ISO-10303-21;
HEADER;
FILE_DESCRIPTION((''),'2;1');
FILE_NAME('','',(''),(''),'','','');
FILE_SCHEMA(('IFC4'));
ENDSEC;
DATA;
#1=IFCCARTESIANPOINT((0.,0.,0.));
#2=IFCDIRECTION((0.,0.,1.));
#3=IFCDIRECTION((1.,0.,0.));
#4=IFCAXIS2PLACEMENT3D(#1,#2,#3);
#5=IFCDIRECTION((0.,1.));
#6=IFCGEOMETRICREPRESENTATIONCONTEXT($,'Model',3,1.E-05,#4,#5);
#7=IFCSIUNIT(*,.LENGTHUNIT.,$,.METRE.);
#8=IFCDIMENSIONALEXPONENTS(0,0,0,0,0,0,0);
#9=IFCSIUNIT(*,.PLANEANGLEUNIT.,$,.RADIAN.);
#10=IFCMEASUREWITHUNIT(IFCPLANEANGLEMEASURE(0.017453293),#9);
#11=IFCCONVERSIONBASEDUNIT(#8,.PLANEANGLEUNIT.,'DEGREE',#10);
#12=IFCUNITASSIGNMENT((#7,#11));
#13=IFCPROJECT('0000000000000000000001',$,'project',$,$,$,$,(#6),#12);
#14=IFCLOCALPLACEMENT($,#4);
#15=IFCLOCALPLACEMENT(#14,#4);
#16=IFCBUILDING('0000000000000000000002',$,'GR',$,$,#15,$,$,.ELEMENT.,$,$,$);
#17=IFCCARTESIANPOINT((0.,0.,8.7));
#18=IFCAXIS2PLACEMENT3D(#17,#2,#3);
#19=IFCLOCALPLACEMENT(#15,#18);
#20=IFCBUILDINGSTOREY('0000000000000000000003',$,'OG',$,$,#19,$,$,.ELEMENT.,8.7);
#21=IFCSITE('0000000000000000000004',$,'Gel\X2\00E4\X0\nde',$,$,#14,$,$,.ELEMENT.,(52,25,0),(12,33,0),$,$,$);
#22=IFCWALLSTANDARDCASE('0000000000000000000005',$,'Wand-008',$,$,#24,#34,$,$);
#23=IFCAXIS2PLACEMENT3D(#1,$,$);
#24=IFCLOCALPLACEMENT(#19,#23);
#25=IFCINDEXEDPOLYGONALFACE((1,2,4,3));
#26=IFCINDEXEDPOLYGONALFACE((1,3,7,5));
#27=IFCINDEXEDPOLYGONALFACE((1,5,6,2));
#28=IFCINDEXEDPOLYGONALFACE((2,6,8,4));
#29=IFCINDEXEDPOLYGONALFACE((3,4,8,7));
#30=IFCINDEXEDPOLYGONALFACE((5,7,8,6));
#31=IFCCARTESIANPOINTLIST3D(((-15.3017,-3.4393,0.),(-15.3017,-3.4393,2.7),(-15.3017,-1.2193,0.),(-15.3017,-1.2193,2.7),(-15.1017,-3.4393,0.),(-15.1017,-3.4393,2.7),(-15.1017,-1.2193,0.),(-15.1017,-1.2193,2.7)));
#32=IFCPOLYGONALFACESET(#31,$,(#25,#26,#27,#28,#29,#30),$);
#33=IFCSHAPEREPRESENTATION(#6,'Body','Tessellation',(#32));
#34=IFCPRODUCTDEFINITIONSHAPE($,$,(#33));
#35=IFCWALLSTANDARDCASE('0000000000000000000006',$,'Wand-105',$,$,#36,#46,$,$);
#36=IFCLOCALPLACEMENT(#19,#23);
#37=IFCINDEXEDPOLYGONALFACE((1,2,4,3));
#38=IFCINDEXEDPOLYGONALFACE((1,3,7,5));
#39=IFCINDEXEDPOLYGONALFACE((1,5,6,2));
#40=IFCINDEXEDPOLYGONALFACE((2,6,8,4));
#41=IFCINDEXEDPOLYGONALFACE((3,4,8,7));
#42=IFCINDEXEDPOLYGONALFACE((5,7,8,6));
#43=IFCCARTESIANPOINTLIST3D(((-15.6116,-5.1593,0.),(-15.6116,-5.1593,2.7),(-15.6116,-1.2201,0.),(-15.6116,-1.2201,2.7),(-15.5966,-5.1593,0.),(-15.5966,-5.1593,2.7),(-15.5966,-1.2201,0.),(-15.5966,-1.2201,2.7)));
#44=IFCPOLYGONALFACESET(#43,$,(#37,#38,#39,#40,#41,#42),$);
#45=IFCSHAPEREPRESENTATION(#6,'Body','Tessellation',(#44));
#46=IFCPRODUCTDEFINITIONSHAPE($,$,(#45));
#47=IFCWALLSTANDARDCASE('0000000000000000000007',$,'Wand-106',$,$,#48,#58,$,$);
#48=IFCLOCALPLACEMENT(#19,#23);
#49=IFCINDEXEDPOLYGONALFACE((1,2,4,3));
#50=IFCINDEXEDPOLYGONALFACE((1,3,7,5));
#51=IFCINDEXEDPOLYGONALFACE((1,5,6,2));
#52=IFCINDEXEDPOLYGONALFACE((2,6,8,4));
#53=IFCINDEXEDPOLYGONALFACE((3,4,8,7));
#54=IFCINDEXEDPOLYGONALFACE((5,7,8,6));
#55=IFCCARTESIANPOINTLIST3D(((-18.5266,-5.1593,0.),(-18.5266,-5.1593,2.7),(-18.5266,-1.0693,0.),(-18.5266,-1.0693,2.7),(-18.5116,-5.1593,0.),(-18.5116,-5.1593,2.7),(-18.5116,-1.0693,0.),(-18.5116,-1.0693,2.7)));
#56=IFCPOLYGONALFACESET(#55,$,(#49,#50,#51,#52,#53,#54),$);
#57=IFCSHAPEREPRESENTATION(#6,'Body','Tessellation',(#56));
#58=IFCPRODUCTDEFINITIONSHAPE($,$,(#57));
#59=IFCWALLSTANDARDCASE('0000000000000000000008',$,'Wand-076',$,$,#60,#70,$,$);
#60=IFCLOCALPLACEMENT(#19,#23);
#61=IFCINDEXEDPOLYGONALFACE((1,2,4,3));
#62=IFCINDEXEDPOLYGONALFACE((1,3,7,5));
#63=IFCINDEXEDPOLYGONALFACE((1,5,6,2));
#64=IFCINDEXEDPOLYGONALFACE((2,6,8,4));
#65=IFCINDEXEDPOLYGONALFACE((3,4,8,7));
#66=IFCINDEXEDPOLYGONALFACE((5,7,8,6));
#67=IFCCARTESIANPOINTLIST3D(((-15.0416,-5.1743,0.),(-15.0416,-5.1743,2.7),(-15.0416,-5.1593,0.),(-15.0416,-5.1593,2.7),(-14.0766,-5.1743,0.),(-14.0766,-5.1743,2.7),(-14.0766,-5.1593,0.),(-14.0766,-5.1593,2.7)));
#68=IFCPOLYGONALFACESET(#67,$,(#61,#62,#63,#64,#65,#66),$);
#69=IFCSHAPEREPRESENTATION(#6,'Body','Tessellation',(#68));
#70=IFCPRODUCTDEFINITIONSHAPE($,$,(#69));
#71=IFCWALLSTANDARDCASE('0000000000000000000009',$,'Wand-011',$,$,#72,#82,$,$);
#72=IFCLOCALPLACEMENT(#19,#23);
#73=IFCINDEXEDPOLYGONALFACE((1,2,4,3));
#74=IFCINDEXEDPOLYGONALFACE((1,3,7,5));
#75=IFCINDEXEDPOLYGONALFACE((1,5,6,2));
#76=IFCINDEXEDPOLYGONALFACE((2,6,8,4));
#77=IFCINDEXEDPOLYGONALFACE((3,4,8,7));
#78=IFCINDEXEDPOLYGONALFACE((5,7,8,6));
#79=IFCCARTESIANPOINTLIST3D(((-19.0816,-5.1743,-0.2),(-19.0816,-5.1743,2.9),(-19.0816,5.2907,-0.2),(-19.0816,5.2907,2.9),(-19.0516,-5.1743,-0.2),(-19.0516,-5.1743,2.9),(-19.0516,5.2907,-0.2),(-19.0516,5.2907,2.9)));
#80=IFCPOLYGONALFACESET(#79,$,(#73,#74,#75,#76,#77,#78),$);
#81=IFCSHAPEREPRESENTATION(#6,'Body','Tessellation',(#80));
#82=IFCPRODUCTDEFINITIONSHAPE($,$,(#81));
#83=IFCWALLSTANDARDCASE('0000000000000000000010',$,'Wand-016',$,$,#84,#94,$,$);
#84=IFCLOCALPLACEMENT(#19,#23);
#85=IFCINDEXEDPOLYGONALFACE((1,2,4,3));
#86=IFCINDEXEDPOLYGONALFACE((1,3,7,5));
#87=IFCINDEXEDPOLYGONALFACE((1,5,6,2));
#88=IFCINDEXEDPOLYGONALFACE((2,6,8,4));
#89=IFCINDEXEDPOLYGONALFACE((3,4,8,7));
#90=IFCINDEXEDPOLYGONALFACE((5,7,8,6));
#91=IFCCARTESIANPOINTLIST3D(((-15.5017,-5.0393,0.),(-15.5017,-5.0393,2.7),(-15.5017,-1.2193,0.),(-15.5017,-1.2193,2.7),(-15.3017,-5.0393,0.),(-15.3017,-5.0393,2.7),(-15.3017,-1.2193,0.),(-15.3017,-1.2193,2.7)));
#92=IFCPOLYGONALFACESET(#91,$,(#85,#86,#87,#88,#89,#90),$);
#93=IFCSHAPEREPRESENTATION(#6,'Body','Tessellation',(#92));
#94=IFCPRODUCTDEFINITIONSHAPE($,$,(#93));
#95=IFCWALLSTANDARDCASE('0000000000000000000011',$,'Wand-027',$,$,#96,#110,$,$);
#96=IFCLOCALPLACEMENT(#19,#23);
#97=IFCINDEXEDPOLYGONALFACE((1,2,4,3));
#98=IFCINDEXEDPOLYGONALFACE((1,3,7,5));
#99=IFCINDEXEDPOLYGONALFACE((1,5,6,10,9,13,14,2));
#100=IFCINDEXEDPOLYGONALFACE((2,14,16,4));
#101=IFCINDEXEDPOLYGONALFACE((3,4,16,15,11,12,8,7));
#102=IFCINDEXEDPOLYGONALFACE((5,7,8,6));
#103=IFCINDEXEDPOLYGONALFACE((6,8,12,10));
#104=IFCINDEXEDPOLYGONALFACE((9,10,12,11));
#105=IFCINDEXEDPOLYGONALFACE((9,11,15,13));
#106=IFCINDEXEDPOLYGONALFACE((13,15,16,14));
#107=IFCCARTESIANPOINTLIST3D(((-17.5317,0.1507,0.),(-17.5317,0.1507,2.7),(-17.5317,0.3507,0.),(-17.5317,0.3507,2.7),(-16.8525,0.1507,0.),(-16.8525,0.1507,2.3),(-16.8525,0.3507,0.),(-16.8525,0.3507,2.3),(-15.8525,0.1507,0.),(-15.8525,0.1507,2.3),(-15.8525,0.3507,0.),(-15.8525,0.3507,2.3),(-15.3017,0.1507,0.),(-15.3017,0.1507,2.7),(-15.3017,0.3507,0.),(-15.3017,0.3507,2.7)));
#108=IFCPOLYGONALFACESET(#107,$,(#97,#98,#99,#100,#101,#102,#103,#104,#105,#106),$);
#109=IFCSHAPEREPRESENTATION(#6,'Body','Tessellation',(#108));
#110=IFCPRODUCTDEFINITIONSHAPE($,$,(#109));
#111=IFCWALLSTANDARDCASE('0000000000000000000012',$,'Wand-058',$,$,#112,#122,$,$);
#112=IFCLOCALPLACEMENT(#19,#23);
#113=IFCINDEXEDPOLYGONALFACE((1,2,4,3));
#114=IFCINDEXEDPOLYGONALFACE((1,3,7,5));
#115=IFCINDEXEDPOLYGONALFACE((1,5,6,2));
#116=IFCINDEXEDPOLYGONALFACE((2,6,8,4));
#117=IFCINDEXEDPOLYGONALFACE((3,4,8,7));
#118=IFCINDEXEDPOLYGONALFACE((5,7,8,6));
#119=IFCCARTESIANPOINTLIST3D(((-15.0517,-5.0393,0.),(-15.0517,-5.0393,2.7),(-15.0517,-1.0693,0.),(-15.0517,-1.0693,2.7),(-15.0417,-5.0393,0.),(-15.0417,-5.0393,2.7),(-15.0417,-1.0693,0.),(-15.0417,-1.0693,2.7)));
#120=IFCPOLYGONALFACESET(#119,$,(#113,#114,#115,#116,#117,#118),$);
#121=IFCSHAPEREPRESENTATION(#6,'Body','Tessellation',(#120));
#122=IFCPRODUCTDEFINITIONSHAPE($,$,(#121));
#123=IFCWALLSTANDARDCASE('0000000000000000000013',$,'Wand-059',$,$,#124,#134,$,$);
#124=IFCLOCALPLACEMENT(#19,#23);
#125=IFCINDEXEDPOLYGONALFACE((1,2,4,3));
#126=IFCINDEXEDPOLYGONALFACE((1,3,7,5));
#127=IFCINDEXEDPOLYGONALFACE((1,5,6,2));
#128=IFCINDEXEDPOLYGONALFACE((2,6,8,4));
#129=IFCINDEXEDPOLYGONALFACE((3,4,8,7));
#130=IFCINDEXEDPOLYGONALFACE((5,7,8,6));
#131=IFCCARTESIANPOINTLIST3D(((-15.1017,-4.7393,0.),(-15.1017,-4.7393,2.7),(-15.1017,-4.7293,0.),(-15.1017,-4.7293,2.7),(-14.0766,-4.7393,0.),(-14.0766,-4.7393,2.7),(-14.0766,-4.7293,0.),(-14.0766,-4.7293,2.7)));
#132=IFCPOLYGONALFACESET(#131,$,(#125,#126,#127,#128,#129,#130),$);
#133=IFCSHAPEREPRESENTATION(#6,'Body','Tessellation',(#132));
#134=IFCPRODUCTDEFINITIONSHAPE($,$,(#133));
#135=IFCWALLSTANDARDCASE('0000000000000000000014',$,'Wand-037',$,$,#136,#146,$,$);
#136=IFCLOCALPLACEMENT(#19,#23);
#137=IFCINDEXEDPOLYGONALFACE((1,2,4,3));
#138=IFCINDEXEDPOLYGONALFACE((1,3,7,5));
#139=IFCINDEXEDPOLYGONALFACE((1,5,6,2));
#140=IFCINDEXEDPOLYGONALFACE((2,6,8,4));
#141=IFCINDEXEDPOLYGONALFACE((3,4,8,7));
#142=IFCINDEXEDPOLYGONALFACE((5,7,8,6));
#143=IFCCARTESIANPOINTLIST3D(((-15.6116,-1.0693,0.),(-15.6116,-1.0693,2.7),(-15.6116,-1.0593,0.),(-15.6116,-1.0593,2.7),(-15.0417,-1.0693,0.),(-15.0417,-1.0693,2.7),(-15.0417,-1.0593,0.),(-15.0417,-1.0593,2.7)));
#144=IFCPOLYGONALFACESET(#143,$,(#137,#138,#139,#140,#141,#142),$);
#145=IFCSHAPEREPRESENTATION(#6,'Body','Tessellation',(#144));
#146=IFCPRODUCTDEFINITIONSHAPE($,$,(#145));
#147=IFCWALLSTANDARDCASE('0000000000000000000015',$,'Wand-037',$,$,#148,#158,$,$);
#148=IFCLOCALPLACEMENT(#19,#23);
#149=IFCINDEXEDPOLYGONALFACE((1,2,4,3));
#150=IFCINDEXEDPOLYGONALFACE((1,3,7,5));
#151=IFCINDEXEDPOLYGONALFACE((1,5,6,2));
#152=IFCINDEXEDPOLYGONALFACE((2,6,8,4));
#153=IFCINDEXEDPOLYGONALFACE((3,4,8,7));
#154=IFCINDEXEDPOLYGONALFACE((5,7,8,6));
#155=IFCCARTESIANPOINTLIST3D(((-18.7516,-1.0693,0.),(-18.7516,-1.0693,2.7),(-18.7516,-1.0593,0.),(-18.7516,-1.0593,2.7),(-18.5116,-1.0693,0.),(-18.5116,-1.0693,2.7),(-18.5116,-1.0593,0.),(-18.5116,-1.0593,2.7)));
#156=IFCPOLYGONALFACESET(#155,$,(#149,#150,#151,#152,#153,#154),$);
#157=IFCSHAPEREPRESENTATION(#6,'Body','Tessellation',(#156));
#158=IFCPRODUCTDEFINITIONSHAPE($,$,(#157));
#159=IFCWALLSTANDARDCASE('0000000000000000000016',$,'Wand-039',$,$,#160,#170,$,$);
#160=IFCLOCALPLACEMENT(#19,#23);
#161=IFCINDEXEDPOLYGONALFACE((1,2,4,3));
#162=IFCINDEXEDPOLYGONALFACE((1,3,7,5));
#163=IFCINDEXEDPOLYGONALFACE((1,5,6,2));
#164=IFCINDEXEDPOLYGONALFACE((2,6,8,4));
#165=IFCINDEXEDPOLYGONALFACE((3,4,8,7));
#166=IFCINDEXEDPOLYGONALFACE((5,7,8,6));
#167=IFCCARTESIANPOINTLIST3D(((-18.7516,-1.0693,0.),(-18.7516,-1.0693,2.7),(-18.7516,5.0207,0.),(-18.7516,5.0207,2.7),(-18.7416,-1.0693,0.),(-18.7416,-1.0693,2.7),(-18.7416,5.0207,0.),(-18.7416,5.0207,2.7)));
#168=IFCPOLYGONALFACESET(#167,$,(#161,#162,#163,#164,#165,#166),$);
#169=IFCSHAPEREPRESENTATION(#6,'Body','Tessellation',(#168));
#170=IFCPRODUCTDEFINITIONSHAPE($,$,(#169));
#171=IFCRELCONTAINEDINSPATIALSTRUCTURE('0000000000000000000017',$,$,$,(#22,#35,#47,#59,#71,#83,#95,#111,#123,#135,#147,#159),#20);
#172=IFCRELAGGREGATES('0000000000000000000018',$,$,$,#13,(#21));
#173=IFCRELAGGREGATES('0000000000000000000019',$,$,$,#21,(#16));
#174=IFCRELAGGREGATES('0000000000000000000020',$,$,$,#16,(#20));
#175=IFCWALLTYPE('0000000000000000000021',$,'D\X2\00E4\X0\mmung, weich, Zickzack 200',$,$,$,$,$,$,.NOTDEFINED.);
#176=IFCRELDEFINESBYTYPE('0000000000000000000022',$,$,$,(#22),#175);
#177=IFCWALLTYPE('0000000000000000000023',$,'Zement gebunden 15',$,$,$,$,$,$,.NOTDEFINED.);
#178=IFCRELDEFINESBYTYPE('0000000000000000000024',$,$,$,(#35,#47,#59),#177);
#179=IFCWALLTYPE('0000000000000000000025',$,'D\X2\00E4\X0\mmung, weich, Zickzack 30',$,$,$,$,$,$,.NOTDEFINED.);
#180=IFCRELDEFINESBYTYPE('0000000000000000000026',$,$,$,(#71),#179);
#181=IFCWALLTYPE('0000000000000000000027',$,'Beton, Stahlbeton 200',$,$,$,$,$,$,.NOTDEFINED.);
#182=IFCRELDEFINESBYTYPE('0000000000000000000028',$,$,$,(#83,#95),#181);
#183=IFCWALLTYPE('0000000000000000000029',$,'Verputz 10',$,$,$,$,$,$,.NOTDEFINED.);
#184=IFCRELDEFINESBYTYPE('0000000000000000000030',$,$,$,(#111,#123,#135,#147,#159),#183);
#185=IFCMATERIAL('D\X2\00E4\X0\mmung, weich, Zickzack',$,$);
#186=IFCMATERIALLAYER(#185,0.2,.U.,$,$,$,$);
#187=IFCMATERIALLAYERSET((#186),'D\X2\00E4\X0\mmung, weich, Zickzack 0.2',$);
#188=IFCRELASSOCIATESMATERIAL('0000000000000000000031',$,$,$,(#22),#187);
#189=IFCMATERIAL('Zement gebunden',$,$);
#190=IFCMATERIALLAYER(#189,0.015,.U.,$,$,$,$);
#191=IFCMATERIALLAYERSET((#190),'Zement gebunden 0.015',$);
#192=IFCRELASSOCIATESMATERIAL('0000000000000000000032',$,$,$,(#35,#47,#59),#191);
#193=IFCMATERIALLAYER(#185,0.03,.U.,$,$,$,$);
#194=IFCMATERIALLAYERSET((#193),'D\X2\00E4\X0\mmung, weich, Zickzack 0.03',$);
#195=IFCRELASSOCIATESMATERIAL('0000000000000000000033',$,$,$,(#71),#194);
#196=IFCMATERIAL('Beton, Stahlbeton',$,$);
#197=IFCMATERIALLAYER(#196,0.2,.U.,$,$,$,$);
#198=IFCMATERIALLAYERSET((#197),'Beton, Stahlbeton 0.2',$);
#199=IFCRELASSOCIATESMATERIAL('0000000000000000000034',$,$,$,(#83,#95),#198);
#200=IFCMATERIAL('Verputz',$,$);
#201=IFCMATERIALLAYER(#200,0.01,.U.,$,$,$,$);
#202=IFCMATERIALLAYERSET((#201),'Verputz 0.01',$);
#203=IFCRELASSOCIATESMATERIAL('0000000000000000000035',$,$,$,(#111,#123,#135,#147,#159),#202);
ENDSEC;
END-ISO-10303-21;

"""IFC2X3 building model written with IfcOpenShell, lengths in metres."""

from ifc_helpers import new_model, entity, si_unit, converted_unit, direction, frame, origin_with_axes, origin_2d_with_axis, place, context, project, spatial, polyline, rectangle, outline, extrude, material, layer, layer_set, layer_usage, type_object, element, save


model = new_model("IFC2X3")

# Units and contexts
model_context = context("Model", 3, precision=1e-05, world=origin_with_axes(), true_north=direction((0.0, 1.0)))
ifc_project = project(units=[si_unit("LENGTHUNIT", "METRE"), converted_unit("PLANEANGLEUNIT", "DEGREE", entity("IfcPlaneAngleMeasure", 0.017453293), si_unit("PLANEANGLEUNIT", "RADIAN"), dimensions=[0, 0, 0, 0, 0, 0, 0])], contexts=[model_context])

# Site, building, storey
site_placement = place(None, origin_with_axes())
site = spatial("IfcSite", under=ifc_project, at=site_placement, Name="Gelände", CompositionType="ELEMENT", RefLatitude=(52, 25, 0), RefLongitude=(12, 33, 0))
building_placement = place(site_placement, origin_with_axes())
building = spatial("IfcBuilding", under=site, at=building_placement, Name="GR", CompositionType="ELEMENT")
storey_placement = place(building_placement, frame((0.0, 0.0, 8.7), z_axis=(0.0, 0.0, 1.0), x_axis=(1.0, 0.0, 0.0)))
storey = spatial("IfcBuildingStorey", under=building, at=storey_placement, Name="OG", CompositionType="ELEMENT", Elevation=8.7)

# Walls
ifc_material_1 = material(Name="Dämmung, weich, Zickzack")
ifc_layer_1 = layer(ifc_material_1, 0.2, ventilated="UNKNOWN")
ifc_layer_set_1 = layer_set([ifc_layer_1], Name="Dämmung, weich, Zickzack 0.2")
ifc_layer_usage_1 = layer_usage(ifc_layer_set_1, "AXIS2", "NEGATIVE", 0.0)
wall_type_1 = type_object("IfcWallType", Name="Dämmung, weich, Zickzack 200", PredefinedType="NOTDEFINED")
wall_1_placement = place(storey_placement, frame((-15.3017, -3.4393, 0.0), z_axis=(0.0, 0.0, 1.0), x_axis=(0.0, 1.0, 0.0)))
element("IfcWallStandardCase", 1, at=wall_1_placement, inside=storey, type_object=wall_type_1, material=ifc_layer_usage_1, Name="Wand-008", context=model_context, shape_type="SweptSolid", body=[
    extrude(outline(polyline([(0.0, -0.2), (2.22, -0.2), (2.22, 0.0), (0.0, 0.0), (0.0, -0.2)])), origin_with_axes(), (0.0, 0.0, 1.0), 2.7),
])
ifc_material_2 = material(Name="Zement gebunden")
ifc_layer_2 = layer(ifc_material_2, 0.015, ventilated="UNKNOWN")
ifc_layer_set_2 = layer_set([ifc_layer_2], Name="Zement gebunden 0.015")
ifc_layer_usage_2 = layer_usage(ifc_layer_set_2, "AXIS2", "NEGATIVE", 0.0)
wall_type_2 = type_object("IfcWallType", Name="Zement gebunden 15", PredefinedType="NOTDEFINED")
wall_2_placement = place(storey_placement, frame((-15.6116, -5.1593, 0.0), z_axis=(0.0, 0.0, 1.0), x_axis=(0.0, 1.0, 0.0)))
element("IfcWallStandardCase", 2, at=wall_2_placement, inside=storey, type_object=wall_type_2, material=ifc_layer_usage_2, Name="Wand-105", context=model_context, shape_type="SweptSolid", body=[
    extrude(outline(polyline([(0.0, -0.015), (3.9392, -0.015), (3.9392, 0.0), (0.0, 0.0), (0.0, -0.015)])), origin_with_axes(), (0.0, 0.0, 1.0), 2.7),
])
ifc_layer_usage_3 = layer_usage(ifc_layer_set_2, "AXIS2", "POSITIVE", 0.0)
wall_3_placement = place(storey_placement, frame((-18.5116, -5.1593, 0.0), z_axis=(0.0, 0.0, 1.0), x_axis=(0.0, 1.0, 0.0)))
element("IfcWallStandardCase", 3, at=wall_3_placement, inside=storey, type_object=wall_type_2, material=ifc_layer_usage_3, Name="Wand-106", context=model_context, shape_type="SweptSolid", body=[
    extrude(outline(polyline([(0.0, 0.0), (4.09, 0.0), (4.09, 0.015), (0.0, 0.015), (0.0, 0.0)])), origin_with_axes(), (0.0, 0.0, 1.0), 2.7),
])
ifc_layer_usage_4 = layer_usage(ifc_layer_set_2, "AXIS2", "NEGATIVE", 0.0)
wall_4_placement = place(storey_placement, frame((-15.0416, -5.1593, 0.0), z_axis=(0.0, 0.0, 1.0), x_axis=(1.0, 0.0, 0.0)))
element("IfcWallStandardCase", 4, at=wall_4_placement, inside=storey, type_object=wall_type_2, material=ifc_layer_usage_4, Name="Wand-076", context=model_context, shape_type="SweptSolid", body=[
    extrude(outline(polyline([(0.0, -0.015), (0.965, -0.015), (0.965, 0.0), (0.0, 0.0), (0.0, -0.015)])), origin_with_axes(), (0.0, 0.0, 1.0), 2.7),
])
ifc_layer_3 = layer(ifc_material_1, 0.03, ventilated="UNKNOWN")
ifc_layer_set_3 = layer_set([ifc_layer_3], Name="Dämmung, weich, Zickzack 0.03")
ifc_layer_usage_5 = layer_usage(ifc_layer_set_3, "AXIS2", "POSITIVE", 0.0)
wall_type_3 = type_object("IfcWallType", Name="Dämmung, weich, Zickzack 30", PredefinedType="NOTDEFINED")
wall_5_placement = place(storey_placement, frame((-19.0516, -5.1743, -0.2), z_axis=(0.0, 0.0, 1.0), x_axis=(0.0, 1.0, 0.0)))
element("IfcWallStandardCase", 5, at=wall_5_placement, inside=storey, type_object=wall_type_3, material=ifc_layer_usage_5, Name="Wand-011", context=model_context, shape_type="SweptSolid", body=[
    extrude(outline(polyline([(0.0, 0.0), (10.465, 0.0), (10.465, 0.03), (0.0, 0.03), (0.0, 0.0)])), origin_with_axes(), (0.0, 0.0, 1.0), 3.1),
])
ifc_material_3 = material(Name="Beton, Stahlbeton")
ifc_layer_4 = layer(ifc_material_3, 0.2, ventilated="UNKNOWN")
ifc_layer_set_4 = layer_set([ifc_layer_4], Name="Beton, Stahlbeton 0.2")
ifc_layer_usage_6 = layer_usage(ifc_layer_set_4, "AXIS2", "NEGATIVE", 0.0)
wall_type_4 = type_object("IfcWallType", Name="Beton, Stahlbeton 200", PredefinedType="NOTDEFINED")
wall_6_placement = place(storey_placement, frame((-15.5017, -5.0393, 0.0), z_axis=(0.0, 0.0, 1.0), x_axis=(0.0, 1.0, 0.0)))
element("IfcWallStandardCase", 6, at=wall_6_placement, inside=storey, type_object=wall_type_4, material=ifc_layer_usage_6, Name="Wand-016", context=model_context, shape_type="SweptSolid", body=[
    extrude(outline(polyline([(0.0, -0.2), (3.82, -0.2), (3.82, 0.0), (0.0, 0.0), (0.0, -0.2)])), origin_with_axes(), (0.0, 0.0, 1.0), 2.7),
])

# Wall, opening
ifc_layer_usage_7 = layer_usage(ifc_layer_set_4, "AXIS2", "NEGATIVE", 0.0)
wall_7_placement = place(storey_placement, frame((-15.3017, 0.1507, 0.0), z_axis=(0.0, 0.0, 1.0), x_axis=(-1.0, 0.0, 0.0)))
wall_7 = element("IfcWallStandardCase", 7, at=wall_7_placement, inside=storey, type_object=wall_type_4, material=ifc_layer_usage_7, Name="Wand-027", context=model_context, shape_type="SweptSolid", body=[
    extrude(outline(polyline([(0.0, -0.2), (2.23, -0.2), (2.23, 0.0), (0.0, 0.0), (0.0, -0.2)])), origin_with_axes(), (0.0, 0.0, 1.0), 2.7),
])
opening_1_placement = place(wall_7_placement, frame((1.0509, 0.0, 0.0), z_axis=(0.0, 0.0, 1.0), x_axis=(1.0, 0.0, 0.0)))
element("IfcOpeningElement", 8, at=opening_1_placement, cuts=wall_7, context=model_context, shape_type="SweptSolid", body=[
    extrude(rectangle(XDim=1.0, YDim=2.3, at=origin_2d_with_axis()), frame((0.0, 0.001, 1.15), z_axis=(0.0, -1.0, 0.0), x_axis=(1.0, 0.0, 0.0)), (0.0, 0.0, 1.0), 0.602),
])

# Walls
ifc_material_4 = material(Name="Verputz")
ifc_layer_5 = layer(ifc_material_4, 0.01, ventilated="UNKNOWN")
ifc_layer_set_5 = layer_set([ifc_layer_5], Name="Verputz 0.01")
ifc_layer_usage_8 = layer_usage(ifc_layer_set_5, "AXIS2", "POSITIVE", 0.0)
wall_type_5 = type_object("IfcWallType", Name="Verputz 10", PredefinedType="NOTDEFINED")
wall_8_placement = place(storey_placement, frame((-15.0517, -1.0693, 0.0), z_axis=(0.0, 0.0, 1.0), x_axis=(0.0, -1.0, 0.0)))
element("IfcWallStandardCase", 9, at=wall_8_placement, inside=storey, type_object=wall_type_5, material=ifc_layer_usage_8, Name="Wand-058", context=model_context, shape_type="SweptSolid", body=[
    extrude(outline(polyline([(0.0, 0.0), (3.97, 0.0), (3.97, 0.01), (0.0, 0.01), (0.0, 0.0)])), origin_with_axes(), (0.0, 0.0, 1.0), 2.7),
])
ifc_layer_usage_9 = layer_usage(ifc_layer_set_5, "AXIS2", "POSITIVE", 0.0)
wall_9_placement = place(storey_placement, frame((-15.1017, -4.7393, 0.0), z_axis=(0.0, 0.0, 1.0), x_axis=(1.0, 0.0, 0.0)))
element("IfcWallStandardCase", 10, at=wall_9_placement, inside=storey, type_object=wall_type_5, material=ifc_layer_usage_9, Name="Wand-059", context=model_context, shape_type="SweptSolid", body=[
    extrude(outline(polyline([(0.0, 0.0), (1.025, 0.0), (1.025, 0.01), (0.0, 0.01), (0.0, 0.0)])), origin_with_axes(), (0.0, 0.0, 1.0), 2.7),
])
ifc_layer_usage_10 = layer_usage(ifc_layer_set_5, "AXIS2", "POSITIVE", 0.0)
wall_10_placement = place(storey_placement, frame((-15.6116, -1.0693, 0.0), z_axis=(0.0, 0.0, 1.0), x_axis=(1.0, 0.0, 0.0)))
element("IfcWallStandardCase", 11, at=wall_10_placement, inside=storey, type_object=wall_type_5, material=ifc_layer_usage_10, Name="Wand-037", context=model_context, shape_type="SweptSolid", body=[
    extrude(outline(polyline([(0.0, 0.0), (0.57, 0.0), (0.57, 0.01), (0.0, 0.01), (0.0, 0.0)])), origin_with_axes(), (0.0, 0.0, 1.0), 2.7),
])
ifc_layer_usage_11 = layer_usage(ifc_layer_set_5, "AXIS2", "POSITIVE", 0.0)
wall_11_placement = place(storey_placement, frame((-18.7516, -1.0693, 0.0), z_axis=(0.0, 0.0, 1.0), x_axis=(1.0, 0.0, 0.0)))
element("IfcWallStandardCase", 12, at=wall_11_placement, inside=storey, type_object=wall_type_5, material=ifc_layer_usage_11, Name="Wand-037", context=model_context, shape_type="SweptSolid", body=[
    extrude(outline(polyline([(0.0, 0.0), (0.24, 0.0), (0.24, 0.01), (0.0, 0.01), (0.0, 0.0)])), origin_with_axes(), (0.0, 0.0, 1.0), 2.7),
])
ifc_layer_usage_12 = layer_usage(ifc_layer_set_5, "AXIS2", "NEGATIVE", 0.0)
wall_12_placement = place(storey_placement, frame((-18.7516, -1.0693, 0.0), z_axis=(0.0, 0.0, 1.0), x_axis=(0.0, 1.0, 0.0)))
element("IfcWallStandardCase", 13, at=wall_12_placement, inside=storey, type_object=wall_type_5, material=ifc_layer_usage_12, Name="Wand-039", context=model_context, shape_type="SweptSolid", body=[
    extrude(outline(polyline([(0.0, -0.01), (6.09, -0.01), (6.09, 0.0), (0.0, 0.0), (0.0, -0.01)])), origin_with_axes(), (0.0, 0.0, 1.0), 2.7),
])

save(model, "model.ifc")
